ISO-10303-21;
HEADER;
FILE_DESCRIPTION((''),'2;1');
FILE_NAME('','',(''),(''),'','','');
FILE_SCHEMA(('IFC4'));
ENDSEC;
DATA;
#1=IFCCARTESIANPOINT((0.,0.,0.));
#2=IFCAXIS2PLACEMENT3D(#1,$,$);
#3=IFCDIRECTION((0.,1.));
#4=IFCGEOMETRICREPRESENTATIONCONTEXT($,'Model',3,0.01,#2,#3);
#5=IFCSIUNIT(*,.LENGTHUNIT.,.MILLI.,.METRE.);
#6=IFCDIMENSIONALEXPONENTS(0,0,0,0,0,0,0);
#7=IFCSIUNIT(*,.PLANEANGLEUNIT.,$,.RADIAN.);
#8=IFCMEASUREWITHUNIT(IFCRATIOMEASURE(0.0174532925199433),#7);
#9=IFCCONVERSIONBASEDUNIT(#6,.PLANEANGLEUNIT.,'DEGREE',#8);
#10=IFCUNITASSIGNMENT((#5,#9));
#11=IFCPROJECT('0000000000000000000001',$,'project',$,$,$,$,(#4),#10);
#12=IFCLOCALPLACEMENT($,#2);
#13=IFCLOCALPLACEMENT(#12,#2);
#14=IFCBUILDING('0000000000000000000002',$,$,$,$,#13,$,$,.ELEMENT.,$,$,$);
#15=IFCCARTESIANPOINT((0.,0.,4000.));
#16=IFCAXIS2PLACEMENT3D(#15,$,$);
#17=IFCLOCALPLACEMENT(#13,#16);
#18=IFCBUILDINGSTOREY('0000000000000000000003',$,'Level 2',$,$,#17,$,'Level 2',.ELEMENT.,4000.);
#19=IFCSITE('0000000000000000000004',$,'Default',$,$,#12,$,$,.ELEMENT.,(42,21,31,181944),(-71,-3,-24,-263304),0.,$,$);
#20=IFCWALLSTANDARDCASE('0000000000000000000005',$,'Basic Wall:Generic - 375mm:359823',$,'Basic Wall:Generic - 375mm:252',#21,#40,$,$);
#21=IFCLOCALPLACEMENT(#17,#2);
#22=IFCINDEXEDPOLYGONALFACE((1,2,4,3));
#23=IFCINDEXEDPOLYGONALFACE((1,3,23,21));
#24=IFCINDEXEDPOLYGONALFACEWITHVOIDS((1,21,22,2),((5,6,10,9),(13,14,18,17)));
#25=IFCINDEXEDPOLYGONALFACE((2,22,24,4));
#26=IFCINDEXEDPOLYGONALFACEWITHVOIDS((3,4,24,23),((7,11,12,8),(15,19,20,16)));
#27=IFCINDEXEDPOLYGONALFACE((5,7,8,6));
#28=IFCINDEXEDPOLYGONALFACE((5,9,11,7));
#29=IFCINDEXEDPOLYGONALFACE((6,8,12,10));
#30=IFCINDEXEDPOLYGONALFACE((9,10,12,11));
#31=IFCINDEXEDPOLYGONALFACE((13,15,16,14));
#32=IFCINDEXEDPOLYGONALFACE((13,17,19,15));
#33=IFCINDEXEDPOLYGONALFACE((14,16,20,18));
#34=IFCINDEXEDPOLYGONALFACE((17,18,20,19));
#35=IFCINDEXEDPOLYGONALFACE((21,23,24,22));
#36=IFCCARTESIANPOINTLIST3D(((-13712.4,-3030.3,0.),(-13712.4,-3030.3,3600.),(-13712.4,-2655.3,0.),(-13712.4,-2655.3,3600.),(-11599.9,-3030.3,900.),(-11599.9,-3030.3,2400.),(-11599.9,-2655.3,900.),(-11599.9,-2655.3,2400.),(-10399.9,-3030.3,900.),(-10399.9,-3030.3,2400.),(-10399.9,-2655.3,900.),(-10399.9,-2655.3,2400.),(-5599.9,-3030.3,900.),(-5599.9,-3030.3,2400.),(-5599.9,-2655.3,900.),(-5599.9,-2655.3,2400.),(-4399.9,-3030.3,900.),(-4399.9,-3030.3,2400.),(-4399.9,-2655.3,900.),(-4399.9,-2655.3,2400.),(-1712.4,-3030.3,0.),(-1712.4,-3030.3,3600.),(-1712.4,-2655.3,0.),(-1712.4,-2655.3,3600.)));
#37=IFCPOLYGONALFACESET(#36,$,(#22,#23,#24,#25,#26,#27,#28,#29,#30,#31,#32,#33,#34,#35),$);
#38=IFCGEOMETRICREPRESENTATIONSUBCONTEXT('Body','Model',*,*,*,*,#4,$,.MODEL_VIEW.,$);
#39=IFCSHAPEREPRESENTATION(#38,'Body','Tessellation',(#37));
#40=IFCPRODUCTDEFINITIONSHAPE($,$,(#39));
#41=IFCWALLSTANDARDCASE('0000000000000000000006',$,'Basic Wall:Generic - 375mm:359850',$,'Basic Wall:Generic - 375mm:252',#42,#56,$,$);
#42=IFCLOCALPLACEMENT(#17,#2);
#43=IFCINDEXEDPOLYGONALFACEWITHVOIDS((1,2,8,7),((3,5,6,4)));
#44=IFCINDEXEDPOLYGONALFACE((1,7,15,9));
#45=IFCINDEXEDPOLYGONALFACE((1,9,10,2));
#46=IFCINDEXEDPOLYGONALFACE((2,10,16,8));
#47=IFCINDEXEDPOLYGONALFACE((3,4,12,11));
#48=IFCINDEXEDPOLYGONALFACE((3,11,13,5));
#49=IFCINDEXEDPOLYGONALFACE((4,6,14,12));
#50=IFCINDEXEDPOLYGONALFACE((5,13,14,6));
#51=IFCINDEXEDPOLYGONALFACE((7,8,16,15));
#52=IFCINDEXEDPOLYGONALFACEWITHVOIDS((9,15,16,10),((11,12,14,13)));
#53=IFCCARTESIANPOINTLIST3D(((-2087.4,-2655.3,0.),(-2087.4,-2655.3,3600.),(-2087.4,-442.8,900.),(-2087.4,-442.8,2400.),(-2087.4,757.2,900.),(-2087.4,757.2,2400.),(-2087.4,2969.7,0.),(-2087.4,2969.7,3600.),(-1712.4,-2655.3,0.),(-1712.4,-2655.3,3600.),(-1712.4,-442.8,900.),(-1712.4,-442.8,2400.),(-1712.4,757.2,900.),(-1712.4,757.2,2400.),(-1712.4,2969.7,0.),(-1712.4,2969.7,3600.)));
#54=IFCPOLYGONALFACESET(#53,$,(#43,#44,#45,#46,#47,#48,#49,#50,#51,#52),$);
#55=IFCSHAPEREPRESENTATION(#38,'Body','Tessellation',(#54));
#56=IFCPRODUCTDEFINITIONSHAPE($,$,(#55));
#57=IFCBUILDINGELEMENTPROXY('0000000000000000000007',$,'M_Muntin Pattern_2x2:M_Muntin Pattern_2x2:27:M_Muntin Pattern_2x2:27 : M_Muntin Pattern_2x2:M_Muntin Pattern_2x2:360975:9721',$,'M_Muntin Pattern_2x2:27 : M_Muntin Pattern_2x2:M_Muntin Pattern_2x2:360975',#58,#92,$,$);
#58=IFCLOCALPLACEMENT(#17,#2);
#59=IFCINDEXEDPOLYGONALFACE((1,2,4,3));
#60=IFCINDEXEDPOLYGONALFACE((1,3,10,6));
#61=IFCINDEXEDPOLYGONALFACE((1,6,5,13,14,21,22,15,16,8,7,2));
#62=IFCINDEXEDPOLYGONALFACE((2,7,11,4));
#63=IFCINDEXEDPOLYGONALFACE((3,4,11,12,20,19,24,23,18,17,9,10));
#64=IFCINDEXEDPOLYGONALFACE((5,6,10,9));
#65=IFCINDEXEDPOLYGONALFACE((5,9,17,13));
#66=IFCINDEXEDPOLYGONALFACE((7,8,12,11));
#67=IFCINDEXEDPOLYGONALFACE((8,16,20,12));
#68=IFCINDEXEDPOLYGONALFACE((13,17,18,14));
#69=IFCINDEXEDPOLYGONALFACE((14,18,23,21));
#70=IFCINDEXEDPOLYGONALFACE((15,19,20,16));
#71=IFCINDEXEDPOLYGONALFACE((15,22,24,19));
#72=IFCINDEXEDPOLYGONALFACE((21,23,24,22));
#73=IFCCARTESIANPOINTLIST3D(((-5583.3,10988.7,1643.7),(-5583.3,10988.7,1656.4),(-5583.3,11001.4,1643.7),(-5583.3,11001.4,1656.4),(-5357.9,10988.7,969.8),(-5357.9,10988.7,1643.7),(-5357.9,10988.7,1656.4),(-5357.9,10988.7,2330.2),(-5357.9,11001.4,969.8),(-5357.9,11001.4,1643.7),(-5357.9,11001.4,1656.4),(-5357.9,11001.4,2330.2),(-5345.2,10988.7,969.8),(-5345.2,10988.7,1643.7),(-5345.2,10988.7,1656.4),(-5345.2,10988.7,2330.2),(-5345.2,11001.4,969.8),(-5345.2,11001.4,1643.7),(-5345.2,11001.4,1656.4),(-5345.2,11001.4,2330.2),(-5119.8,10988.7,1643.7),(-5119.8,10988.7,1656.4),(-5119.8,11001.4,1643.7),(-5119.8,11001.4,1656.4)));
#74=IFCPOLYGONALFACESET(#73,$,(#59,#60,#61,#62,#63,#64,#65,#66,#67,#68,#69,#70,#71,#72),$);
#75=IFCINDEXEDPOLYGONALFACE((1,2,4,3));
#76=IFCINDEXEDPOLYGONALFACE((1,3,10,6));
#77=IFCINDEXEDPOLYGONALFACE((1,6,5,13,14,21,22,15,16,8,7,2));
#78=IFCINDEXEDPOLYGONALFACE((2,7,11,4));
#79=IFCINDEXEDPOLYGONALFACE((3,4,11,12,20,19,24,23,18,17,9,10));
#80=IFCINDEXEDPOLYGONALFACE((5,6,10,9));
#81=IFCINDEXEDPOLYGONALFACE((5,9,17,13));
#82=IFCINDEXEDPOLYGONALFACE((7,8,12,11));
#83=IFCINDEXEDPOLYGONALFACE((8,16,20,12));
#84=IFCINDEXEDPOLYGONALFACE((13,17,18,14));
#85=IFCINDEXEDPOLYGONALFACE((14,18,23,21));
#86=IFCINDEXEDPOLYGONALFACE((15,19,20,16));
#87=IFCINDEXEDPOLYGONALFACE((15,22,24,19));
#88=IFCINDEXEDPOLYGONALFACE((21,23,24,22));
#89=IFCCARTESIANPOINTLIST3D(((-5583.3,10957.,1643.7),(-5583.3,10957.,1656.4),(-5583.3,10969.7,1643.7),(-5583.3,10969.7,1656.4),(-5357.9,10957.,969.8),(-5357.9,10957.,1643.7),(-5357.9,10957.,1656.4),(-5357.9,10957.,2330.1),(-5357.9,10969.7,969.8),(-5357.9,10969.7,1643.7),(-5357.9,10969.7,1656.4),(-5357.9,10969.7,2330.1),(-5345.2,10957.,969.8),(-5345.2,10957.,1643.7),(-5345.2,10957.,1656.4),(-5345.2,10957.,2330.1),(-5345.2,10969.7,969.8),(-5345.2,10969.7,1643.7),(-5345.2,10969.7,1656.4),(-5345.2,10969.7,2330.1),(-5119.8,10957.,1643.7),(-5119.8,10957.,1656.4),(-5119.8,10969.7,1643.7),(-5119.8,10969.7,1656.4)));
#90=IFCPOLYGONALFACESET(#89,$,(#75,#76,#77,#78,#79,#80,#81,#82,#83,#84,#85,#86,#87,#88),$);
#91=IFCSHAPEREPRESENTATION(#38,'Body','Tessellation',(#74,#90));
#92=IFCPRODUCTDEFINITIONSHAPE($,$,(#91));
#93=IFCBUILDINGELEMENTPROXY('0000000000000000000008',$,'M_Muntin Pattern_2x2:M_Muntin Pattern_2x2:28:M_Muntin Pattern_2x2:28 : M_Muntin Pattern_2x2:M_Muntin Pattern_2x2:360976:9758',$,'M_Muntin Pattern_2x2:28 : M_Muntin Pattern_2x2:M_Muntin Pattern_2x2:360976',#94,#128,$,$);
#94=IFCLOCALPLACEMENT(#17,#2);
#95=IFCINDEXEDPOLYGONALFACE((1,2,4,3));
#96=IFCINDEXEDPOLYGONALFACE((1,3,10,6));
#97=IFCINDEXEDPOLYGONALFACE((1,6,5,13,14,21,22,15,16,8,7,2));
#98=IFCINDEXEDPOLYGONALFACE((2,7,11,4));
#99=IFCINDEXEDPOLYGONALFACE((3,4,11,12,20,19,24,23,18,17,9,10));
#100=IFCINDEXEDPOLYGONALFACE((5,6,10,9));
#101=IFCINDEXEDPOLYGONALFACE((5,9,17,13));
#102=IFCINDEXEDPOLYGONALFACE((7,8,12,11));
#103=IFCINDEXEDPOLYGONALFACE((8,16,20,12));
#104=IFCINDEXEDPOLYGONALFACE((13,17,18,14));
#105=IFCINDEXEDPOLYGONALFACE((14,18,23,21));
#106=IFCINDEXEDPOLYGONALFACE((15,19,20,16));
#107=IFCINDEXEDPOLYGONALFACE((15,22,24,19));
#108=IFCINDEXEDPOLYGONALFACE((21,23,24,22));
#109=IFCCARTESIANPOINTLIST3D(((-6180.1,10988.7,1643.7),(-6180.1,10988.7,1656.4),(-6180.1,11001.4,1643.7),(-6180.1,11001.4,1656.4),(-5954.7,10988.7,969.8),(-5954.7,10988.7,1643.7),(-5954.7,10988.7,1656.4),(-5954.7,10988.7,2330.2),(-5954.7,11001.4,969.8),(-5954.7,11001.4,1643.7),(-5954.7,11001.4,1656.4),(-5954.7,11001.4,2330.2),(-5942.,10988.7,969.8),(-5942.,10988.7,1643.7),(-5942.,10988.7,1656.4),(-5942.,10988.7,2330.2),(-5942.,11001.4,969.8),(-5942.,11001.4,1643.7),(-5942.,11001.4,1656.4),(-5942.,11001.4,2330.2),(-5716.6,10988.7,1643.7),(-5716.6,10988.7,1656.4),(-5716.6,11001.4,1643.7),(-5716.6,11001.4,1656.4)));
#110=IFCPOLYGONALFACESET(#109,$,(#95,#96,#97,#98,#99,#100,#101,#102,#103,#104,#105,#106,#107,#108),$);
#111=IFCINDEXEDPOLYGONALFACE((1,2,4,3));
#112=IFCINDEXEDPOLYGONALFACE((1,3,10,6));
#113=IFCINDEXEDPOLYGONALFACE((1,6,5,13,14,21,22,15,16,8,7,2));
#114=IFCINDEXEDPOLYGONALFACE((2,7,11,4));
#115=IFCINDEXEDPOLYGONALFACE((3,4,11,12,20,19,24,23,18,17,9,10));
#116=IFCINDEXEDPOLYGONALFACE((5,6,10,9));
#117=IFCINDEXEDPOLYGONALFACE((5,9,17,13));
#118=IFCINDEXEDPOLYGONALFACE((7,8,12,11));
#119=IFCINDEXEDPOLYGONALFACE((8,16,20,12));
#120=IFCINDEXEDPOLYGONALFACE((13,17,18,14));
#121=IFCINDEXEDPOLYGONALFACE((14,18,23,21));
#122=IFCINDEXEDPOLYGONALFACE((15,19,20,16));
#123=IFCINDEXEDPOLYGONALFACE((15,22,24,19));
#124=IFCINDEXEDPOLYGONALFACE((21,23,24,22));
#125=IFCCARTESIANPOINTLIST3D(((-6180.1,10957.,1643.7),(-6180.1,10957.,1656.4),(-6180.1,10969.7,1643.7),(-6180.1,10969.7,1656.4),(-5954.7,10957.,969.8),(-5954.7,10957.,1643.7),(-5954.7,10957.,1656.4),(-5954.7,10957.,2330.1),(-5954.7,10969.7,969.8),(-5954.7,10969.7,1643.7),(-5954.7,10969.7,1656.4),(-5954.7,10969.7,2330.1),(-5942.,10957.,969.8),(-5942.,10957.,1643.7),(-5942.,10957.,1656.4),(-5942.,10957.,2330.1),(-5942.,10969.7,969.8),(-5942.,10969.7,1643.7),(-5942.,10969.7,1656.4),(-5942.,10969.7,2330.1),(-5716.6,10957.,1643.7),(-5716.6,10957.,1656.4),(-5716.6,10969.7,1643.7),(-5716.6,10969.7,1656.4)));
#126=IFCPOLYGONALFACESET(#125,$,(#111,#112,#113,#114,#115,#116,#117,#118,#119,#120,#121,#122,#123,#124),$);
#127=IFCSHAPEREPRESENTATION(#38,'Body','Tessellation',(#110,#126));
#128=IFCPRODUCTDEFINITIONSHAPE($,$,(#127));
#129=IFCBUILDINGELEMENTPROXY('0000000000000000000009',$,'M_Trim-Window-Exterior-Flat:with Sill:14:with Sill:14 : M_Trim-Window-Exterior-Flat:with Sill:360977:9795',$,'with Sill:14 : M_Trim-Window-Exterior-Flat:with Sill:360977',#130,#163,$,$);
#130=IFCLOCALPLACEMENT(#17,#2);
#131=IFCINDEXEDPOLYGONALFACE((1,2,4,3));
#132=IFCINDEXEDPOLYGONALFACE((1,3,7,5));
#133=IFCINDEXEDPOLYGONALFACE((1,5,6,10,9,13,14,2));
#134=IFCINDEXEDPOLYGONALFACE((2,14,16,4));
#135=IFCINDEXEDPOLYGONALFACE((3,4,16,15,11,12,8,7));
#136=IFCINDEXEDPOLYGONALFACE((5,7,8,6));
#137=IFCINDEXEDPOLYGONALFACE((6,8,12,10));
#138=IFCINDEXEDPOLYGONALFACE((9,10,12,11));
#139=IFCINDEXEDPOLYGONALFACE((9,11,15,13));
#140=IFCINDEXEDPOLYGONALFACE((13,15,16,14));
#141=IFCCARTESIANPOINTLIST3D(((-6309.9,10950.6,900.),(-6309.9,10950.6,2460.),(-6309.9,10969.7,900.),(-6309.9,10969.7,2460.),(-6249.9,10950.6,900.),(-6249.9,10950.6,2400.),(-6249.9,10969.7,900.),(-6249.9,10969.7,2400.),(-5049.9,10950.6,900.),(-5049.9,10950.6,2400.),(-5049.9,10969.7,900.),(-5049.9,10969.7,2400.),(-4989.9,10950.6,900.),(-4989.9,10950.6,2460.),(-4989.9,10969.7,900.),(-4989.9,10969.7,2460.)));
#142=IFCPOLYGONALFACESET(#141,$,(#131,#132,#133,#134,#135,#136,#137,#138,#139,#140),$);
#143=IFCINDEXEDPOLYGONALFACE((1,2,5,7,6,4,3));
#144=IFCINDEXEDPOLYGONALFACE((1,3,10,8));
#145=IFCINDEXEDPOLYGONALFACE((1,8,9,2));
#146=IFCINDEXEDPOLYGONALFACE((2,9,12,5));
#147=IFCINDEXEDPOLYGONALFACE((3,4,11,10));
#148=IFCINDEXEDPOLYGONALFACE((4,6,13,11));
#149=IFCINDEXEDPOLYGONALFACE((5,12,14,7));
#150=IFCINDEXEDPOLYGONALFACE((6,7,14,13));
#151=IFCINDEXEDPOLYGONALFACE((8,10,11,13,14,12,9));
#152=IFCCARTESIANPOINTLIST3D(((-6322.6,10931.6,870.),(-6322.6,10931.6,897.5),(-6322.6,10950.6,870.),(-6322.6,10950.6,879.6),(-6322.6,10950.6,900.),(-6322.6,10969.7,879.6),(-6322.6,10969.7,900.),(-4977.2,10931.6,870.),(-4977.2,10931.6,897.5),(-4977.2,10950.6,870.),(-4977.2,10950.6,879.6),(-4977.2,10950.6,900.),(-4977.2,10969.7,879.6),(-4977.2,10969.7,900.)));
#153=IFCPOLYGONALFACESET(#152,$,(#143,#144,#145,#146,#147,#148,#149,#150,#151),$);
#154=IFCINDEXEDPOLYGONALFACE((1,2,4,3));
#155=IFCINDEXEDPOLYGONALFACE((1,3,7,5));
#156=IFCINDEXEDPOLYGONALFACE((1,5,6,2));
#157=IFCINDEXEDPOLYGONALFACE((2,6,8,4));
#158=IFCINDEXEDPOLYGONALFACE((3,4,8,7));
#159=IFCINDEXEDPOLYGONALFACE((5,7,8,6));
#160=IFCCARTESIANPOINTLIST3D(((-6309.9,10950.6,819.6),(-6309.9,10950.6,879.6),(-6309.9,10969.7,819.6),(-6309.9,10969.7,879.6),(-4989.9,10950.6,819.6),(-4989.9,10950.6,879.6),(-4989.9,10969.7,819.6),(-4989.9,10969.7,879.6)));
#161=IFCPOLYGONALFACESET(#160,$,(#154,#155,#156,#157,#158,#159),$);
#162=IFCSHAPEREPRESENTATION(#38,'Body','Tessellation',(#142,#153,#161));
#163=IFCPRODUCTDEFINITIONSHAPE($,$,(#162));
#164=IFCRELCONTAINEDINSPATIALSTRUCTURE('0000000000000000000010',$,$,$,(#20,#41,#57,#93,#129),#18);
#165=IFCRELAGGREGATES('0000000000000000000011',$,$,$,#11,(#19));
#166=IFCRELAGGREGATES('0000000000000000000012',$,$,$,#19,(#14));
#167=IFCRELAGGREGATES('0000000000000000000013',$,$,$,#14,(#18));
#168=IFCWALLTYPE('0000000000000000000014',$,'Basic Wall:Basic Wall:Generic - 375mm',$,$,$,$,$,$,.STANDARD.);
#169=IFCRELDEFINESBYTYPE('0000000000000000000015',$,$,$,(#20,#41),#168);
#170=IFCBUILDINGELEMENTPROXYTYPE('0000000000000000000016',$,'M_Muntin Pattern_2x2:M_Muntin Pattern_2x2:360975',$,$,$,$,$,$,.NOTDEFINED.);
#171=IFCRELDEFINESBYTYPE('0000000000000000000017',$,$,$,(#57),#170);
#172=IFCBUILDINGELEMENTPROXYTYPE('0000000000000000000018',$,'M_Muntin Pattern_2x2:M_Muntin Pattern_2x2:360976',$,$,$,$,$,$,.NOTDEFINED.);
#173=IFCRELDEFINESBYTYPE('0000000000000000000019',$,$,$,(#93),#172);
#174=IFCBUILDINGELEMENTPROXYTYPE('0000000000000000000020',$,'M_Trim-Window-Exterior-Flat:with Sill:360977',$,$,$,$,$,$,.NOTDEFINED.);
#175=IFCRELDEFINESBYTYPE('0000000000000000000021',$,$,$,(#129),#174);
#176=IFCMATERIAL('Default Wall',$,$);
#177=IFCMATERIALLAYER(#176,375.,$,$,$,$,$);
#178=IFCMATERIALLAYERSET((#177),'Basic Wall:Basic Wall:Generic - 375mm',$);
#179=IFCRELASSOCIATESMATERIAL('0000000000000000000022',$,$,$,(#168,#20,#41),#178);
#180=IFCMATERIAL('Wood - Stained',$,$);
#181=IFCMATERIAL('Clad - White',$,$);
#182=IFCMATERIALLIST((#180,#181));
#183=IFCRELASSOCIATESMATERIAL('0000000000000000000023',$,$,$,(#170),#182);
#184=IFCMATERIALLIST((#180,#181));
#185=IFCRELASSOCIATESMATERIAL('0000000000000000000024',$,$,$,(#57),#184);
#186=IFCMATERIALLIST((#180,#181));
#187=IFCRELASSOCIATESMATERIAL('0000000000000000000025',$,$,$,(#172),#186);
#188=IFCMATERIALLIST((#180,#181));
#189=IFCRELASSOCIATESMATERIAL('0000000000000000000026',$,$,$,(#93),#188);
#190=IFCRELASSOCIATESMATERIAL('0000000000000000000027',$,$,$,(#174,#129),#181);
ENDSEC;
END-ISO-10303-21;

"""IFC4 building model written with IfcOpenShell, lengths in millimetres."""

from ifc_helpers import new_model, entity, si_unit, converted_unit, direction, frame, frame_2d, origin, place, context, subcontext, project, spatial, polyline, rectangle, outline, extrude, source, transform, mapped, material, material_list, layer, layer_set, layer_usage, type_object, type_shapes, element, save


model = new_model("IFC4")

# Units and contexts
model_context = context("Model", 3, precision=0.01, world=origin(), true_north=direction((0.0, 1.0)))
body_context = subcontext(model_context, "Body", "Model", "MODEL_VIEW")
ifc_project = project(units=[si_unit("LENGTHUNIT", "METRE", prefix="MILLI"), converted_unit("PLANEANGLEUNIT", "DEGREE", entity("IfcRatioMeasure", 0.0174532925199433), si_unit("PLANEANGLEUNIT", "RADIAN"), dimensions=[0, 0, 0, 0, 0, 0, 0])], contexts=[model_context])

# Site, building, storey
site_placement = place(None, origin())
site = spatial("IfcSite", under=ifc_project, at=site_placement, Name="Default", CompositionType="ELEMENT", RefLatitude=(42, 21, 31, 181944), RefLongitude=(-71, -3, -24, -263304), RefElevation=0.0)
building_placement = place(site_placement, origin())
building = spatial("IfcBuilding", under=site, at=building_placement, CompositionType="ELEMENT")
storey_placement = place(building_placement, frame((0.0, 0.0, 4000.0)))
storey = spatial("IfcBuildingStorey", under=building, at=storey_placement, Name="Level 2", LongName="Level 2", CompositionType="ELEMENT", Elevation=4000.0)

# Wall, openings
ifc_material_1 = material(Name="Default Wall")
ifc_layer_1 = layer(ifc_material_1, 375.0)
ifc_layer_set_1 = layer_set([ifc_layer_1], Name="Basic Wall:Basic Wall:Generic - 375mm")
ifc_layer_usage_1 = layer_usage(ifc_layer_set_1, "AXIS2", "NEGATIVE", 187.5)
wall_type = type_object("IfcWallType", Name="Basic Wall:Basic Wall:Generic - 375mm", PredefinedType="STANDARD", material=ifc_layer_set_1)
wall_1_placement = place(storey_placement, frame((-13712.4, -2842.8, 0.0)))
wall_1 = element("IfcWallStandardCase", 1, at=wall_1_placement, inside=storey, type_object=wall_type, material=ifc_layer_usage_1, Name="Basic Wall:Generic - 375mm:359823", ObjectType="Basic Wall:Generic - 375mm:252", context=body_context, shape_type="SweptSolid", body=[
    extrude(rectangle(XDim=12000.0, YDim=375.0, at=frame_2d((6000.0, 0.0), x_axis=(-1.0, 0.0))), origin(), (0.0, 0.0, 1.0), 3600.0),
])
opening_1_placement = place(wall_1_placement, frame((13712.4, 2842.8, 0.0)))
element("IfcOpeningElement", 2, at=opening_1_placement, cuts=wall_1, ObjectType="Opening", context=body_context, shape_type="SweptSolid", body=[
    extrude(rectangle(XDim=1500.0, YDim=1200.0, at=frame_2d((0.0, 0.0), x_axis=(0.0, 1.0))), frame((-10999.9, -3034.1, 1650.0), z_axis=(0.0, 1.0, 0.0), x_axis=(-1.0, 0.0, 0.0)), (0.0, 0.0, 1.0), 382.5),
])
opening_2_placement = place(wall_1_placement, frame((13712.4, 2842.8, 0.0)))
element("IfcOpeningElement", 3, at=opening_2_placement, cuts=wall_1, ObjectType="Opening", context=body_context, shape_type="SweptSolid", body=[
    extrude(rectangle(XDim=1500.0, YDim=1200.0, at=frame_2d((0.0, 0.0), x_axis=(0.0, 1.0))), frame((-4999.9, -3034.1, 1650.0), z_axis=(0.0, 1.0, 0.0), x_axis=(-1.0, 0.0, 0.0)), (0.0, 0.0, 1.0), 382.5),
])

# Wall, opening
ifc_layer_usage_2 = layer_usage(ifc_layer_set_1, "AXIS2", "NEGATIVE", 187.5)
wall_2_placement = place(storey_placement, frame((-1899.9, -2655.3, 0.0), z_axis=(0.0, 0.0, 1.0), x_axis=(0.0, 1.0, 0.0)))
wall_2 = element("IfcWallStandardCase", 4, at=wall_2_placement, inside=storey, type_object=wall_type, material=ifc_layer_usage_2, Name="Basic Wall:Generic - 375mm:359850", ObjectType="Basic Wall:Generic - 375mm:252", context=body_context, shape_type="SweptSolid", body=[
    extrude(rectangle(XDim=5625.0, YDim=375.0, at=frame_2d((2812.5, 0.0), x_axis=(-1.0, 0.0))), origin(), (0.0, 0.0, 1.0), 3600.0),
])
opening_3_placement = place(wall_2_placement, frame((2655.3, -1899.9, 0.0), z_axis=(0.0, 0.0, 1.0), x_axis=(0.0, -1.0, 0.0)))
element("IfcOpeningElement", 5, at=opening_3_placement, cuts=wall_2, ObjectType="Opening", context=body_context, shape_type="SweptSolid", body=[
    extrude(rectangle(XDim=1500.0, YDim=1200.0, at=frame_2d((0.0, 0.0), x_axis=(0.0, 1.0))), frame((-1708.7, 157.2, 1650.0), z_axis=(-1.0, 0.0, 0.0), x_axis=(0.0, -1.0, 0.0)), (0.0, 0.0, 1.0), 382.5),
])

# Building element proxies
ifc_material_2 = material(Name="Wood - Stained")
ifc_material_3 = material(Name="Clad - White")
ifc_material_list_1 = material_list([ifc_material_2, ifc_material_3])
ifc_material_list_2 = material_list([ifc_material_2, ifc_material_3])
building_element_proxy_type_1 = type_object("IfcBuildingElementProxyType", Name="M_Muntin Pattern_2x2:M_Muntin Pattern_2x2:360975", PredefinedType="NOTDEFINED", material=ifc_material_list_2)
shared_shape_1 = source(origin(), body_context, "Body", "SweptSolid", [
    extrude(outline(polyline([(-680.2, 6.4), (-680.2, -6.3), (-6.4, -6.3), (-6.4, -231.7), (6.3, -231.7), (6.3, -6.3), (680.2, -6.3), (680.2, 6.4), (6.3, 6.4), (6.3, 231.7), (-6.4, 231.7), (-6.4, 6.4), (-680.2, 6.4)])), frame((-5351.5, 10988.7, 5650.0), z_axis=(0.0, -1.0, 0.0), x_axis=(0.0, 0.0, -1.0)), (0.0, 0.0, -1.0), 12.7),
    extrude(outline(polyline([(-680.1, 6.4), (-680.1, -6.3), (-6.4, -6.3), (-6.4, -231.7), (6.3, -231.7), (6.3, -6.3), (680.2, -6.3), (680.2, 6.4), (6.3, 6.4), (6.3, 231.7), (-6.4, 231.7), (-6.4, 6.4), (-680.1, 6.4)])), frame((-5351.5, 10957.0, 5650.0), z_axis=(0.0, -1.0, 0.0), x_axis=(0.0, 0.0, -1.0)), (0.0, 0.0, -1.0), 12.7),
])
type_shapes(building_element_proxy_type_1, [shared_shape_1])
proxy_1_placement = place(storey_placement, frame((0.0, 0.0, -4000.0)))
element("IfcBuildingElementProxy", 6, at=proxy_1_placement, inside=storey, type_object=building_element_proxy_type_1, material=ifc_material_list_1, Name="M_Muntin Pattern_2x2:M_Muntin Pattern_2x2:27:M_Muntin Pattern_2x2:27 : M_Muntin Pattern_2x2:M_Muntin Pattern_2x2:360975:9721", ObjectType="M_Muntin Pattern_2x2:27 : M_Muntin Pattern_2x2:M_Muntin Pattern_2x2:360975", context=body_context, shape_type="MappedRepresentation", body=[
    mapped(shared_shape_1, transform((0.0, 0.0, 0.0), scale=1.0)),
])
ifc_material_list_3 = material_list([ifc_material_2, ifc_material_3])
ifc_material_list_4 = material_list([ifc_material_2, ifc_material_3])
building_element_proxy_type_2 = type_object("IfcBuildingElementProxyType", Name="M_Muntin Pattern_2x2:M_Muntin Pattern_2x2:360976", PredefinedType="NOTDEFINED", material=ifc_material_list_4)
shared_shape_2 = source(origin(), body_context, "Body", "SweptSolid", [
    extrude(outline(polyline([(-6.4, -680.1), (6.3, -680.1), (6.3, -6.4), (231.7, -6.4), (231.7, 6.3), (6.3, 6.3), (6.3, 680.2), (-6.4, 680.2), (-6.4, 6.3), (-231.7, 6.3), (-231.7, -6.4), (-6.4, -6.4), (-6.4, -680.1)])), frame((-5948.4, 10988.7, 5650.0), z_axis=(0.0, 1.0, 0.0), x_axis=(1.0, 0.0, 0.0)), (0.0, 0.0, 1.0), 12.7),
    extrude(outline(polyline([(-6.4, -680.1), (6.3, -680.1), (6.3, -6.4), (231.7, -6.4), (231.7, 6.3), (6.3, 6.3), (6.3, 680.2), (-6.4, 680.2), (-6.4, 6.3), (-231.7, 6.3), (-231.7, -6.4), (-6.4, -6.4), (-6.4, -680.1)])), frame((-5948.4, 10957.0, 5650.0), z_axis=(0.0, 1.0, 0.0), x_axis=(1.0, 0.0, 0.0)), (0.0, 0.0, 1.0), 12.7),
])
type_shapes(building_element_proxy_type_2, [shared_shape_2])
proxy_2_placement = place(storey_placement, frame((0.0, 0.0, -4000.0)))
element("IfcBuildingElementProxy", 7, at=proxy_2_placement, inside=storey, type_object=building_element_proxy_type_2, material=ifc_material_list_3, Name="M_Muntin Pattern_2x2:M_Muntin Pattern_2x2:28:M_Muntin Pattern_2x2:28 : M_Muntin Pattern_2x2:M_Muntin Pattern_2x2:360976:9758", ObjectType="M_Muntin Pattern_2x2:28 : M_Muntin Pattern_2x2:M_Muntin Pattern_2x2:360976", context=body_context, shape_type="MappedRepresentation", body=[
    mapped(shared_shape_2, transform((0.0, 0.0, 0.0), scale=1.0)),
])
building_element_proxy_type_3 = type_object("IfcBuildingElementProxyType", Name="M_Trim-Window-Exterior-Flat:with Sill:360977", PredefinedType="NOTDEFINED", material=ifc_material_3)
shared_shape_3 = source(origin(), body_context, "Body", "SweptSolid", [
    extrude(outline(polyline([(-765.0, -660.0), (795.0, -660.0), (795.0, 660.0), (-765.0, 660.0), (-765.0, 600.0), (735.0, 600.0), (735.0, -600.0), (-765.0, -600.0), (-765.0, -660.0)])), frame((-5649.9, 10950.6, 5665.0), z_axis=(0.0, 1.0, 0.0), x_axis=(0.0, 0.0, 1.0)), (0.0, 0.0, 1.0), 19.1),
    extrude(outline(polyline([(-15.2, 0.0), (-15.2, -19.0), (12.3, -19.0), (14.8, 0.0), (14.8, 19.0), (-5.7, 19.0), (-5.7, 0.0), (-15.2, 0.0)])), frame((-6322.6, 10950.6, 4885.2), z_axis=(-1.0, 0.0, 0.0), x_axis=(0.0, 0.0, 1.0)), (0.0, 0.0, -1.0), 1345.4),
    extrude(rectangle(XDim=19.1, YDim=1320.0, at=frame_2d((0.0, 0.0), x_axis=(1.0, 0.0))), frame((-5649.9, 10960.1, 4819.6), z_axis=(0.0, 0.0, 1.0), x_axis=(0.0, 1.0, 0.0)), (0.0, 0.0, 1.0), 60.0),
])
type_shapes(building_element_proxy_type_3, [shared_shape_3])
proxy_3_placement = place(storey_placement, frame((0.0, 0.0, -4000.0)))
element("IfcBuildingElementProxy", 8, at=proxy_3_placement, inside=storey, type_object=building_element_proxy_type_3, material=ifc_material_3, Name="M_Trim-Window-Exterior-Flat:with Sill:14:with Sill:14 : M_Trim-Window-Exterior-Flat:with Sill:360977:9795", ObjectType="with Sill:14 : M_Trim-Window-Exterior-Flat:with Sill:360977", context=body_context, shape_type="MappedRepresentation", body=[
    mapped(shared_shape_3, transform((0.0, 0.0, 0.0), scale=1.0)),
])

save(model, "model.ifc")
